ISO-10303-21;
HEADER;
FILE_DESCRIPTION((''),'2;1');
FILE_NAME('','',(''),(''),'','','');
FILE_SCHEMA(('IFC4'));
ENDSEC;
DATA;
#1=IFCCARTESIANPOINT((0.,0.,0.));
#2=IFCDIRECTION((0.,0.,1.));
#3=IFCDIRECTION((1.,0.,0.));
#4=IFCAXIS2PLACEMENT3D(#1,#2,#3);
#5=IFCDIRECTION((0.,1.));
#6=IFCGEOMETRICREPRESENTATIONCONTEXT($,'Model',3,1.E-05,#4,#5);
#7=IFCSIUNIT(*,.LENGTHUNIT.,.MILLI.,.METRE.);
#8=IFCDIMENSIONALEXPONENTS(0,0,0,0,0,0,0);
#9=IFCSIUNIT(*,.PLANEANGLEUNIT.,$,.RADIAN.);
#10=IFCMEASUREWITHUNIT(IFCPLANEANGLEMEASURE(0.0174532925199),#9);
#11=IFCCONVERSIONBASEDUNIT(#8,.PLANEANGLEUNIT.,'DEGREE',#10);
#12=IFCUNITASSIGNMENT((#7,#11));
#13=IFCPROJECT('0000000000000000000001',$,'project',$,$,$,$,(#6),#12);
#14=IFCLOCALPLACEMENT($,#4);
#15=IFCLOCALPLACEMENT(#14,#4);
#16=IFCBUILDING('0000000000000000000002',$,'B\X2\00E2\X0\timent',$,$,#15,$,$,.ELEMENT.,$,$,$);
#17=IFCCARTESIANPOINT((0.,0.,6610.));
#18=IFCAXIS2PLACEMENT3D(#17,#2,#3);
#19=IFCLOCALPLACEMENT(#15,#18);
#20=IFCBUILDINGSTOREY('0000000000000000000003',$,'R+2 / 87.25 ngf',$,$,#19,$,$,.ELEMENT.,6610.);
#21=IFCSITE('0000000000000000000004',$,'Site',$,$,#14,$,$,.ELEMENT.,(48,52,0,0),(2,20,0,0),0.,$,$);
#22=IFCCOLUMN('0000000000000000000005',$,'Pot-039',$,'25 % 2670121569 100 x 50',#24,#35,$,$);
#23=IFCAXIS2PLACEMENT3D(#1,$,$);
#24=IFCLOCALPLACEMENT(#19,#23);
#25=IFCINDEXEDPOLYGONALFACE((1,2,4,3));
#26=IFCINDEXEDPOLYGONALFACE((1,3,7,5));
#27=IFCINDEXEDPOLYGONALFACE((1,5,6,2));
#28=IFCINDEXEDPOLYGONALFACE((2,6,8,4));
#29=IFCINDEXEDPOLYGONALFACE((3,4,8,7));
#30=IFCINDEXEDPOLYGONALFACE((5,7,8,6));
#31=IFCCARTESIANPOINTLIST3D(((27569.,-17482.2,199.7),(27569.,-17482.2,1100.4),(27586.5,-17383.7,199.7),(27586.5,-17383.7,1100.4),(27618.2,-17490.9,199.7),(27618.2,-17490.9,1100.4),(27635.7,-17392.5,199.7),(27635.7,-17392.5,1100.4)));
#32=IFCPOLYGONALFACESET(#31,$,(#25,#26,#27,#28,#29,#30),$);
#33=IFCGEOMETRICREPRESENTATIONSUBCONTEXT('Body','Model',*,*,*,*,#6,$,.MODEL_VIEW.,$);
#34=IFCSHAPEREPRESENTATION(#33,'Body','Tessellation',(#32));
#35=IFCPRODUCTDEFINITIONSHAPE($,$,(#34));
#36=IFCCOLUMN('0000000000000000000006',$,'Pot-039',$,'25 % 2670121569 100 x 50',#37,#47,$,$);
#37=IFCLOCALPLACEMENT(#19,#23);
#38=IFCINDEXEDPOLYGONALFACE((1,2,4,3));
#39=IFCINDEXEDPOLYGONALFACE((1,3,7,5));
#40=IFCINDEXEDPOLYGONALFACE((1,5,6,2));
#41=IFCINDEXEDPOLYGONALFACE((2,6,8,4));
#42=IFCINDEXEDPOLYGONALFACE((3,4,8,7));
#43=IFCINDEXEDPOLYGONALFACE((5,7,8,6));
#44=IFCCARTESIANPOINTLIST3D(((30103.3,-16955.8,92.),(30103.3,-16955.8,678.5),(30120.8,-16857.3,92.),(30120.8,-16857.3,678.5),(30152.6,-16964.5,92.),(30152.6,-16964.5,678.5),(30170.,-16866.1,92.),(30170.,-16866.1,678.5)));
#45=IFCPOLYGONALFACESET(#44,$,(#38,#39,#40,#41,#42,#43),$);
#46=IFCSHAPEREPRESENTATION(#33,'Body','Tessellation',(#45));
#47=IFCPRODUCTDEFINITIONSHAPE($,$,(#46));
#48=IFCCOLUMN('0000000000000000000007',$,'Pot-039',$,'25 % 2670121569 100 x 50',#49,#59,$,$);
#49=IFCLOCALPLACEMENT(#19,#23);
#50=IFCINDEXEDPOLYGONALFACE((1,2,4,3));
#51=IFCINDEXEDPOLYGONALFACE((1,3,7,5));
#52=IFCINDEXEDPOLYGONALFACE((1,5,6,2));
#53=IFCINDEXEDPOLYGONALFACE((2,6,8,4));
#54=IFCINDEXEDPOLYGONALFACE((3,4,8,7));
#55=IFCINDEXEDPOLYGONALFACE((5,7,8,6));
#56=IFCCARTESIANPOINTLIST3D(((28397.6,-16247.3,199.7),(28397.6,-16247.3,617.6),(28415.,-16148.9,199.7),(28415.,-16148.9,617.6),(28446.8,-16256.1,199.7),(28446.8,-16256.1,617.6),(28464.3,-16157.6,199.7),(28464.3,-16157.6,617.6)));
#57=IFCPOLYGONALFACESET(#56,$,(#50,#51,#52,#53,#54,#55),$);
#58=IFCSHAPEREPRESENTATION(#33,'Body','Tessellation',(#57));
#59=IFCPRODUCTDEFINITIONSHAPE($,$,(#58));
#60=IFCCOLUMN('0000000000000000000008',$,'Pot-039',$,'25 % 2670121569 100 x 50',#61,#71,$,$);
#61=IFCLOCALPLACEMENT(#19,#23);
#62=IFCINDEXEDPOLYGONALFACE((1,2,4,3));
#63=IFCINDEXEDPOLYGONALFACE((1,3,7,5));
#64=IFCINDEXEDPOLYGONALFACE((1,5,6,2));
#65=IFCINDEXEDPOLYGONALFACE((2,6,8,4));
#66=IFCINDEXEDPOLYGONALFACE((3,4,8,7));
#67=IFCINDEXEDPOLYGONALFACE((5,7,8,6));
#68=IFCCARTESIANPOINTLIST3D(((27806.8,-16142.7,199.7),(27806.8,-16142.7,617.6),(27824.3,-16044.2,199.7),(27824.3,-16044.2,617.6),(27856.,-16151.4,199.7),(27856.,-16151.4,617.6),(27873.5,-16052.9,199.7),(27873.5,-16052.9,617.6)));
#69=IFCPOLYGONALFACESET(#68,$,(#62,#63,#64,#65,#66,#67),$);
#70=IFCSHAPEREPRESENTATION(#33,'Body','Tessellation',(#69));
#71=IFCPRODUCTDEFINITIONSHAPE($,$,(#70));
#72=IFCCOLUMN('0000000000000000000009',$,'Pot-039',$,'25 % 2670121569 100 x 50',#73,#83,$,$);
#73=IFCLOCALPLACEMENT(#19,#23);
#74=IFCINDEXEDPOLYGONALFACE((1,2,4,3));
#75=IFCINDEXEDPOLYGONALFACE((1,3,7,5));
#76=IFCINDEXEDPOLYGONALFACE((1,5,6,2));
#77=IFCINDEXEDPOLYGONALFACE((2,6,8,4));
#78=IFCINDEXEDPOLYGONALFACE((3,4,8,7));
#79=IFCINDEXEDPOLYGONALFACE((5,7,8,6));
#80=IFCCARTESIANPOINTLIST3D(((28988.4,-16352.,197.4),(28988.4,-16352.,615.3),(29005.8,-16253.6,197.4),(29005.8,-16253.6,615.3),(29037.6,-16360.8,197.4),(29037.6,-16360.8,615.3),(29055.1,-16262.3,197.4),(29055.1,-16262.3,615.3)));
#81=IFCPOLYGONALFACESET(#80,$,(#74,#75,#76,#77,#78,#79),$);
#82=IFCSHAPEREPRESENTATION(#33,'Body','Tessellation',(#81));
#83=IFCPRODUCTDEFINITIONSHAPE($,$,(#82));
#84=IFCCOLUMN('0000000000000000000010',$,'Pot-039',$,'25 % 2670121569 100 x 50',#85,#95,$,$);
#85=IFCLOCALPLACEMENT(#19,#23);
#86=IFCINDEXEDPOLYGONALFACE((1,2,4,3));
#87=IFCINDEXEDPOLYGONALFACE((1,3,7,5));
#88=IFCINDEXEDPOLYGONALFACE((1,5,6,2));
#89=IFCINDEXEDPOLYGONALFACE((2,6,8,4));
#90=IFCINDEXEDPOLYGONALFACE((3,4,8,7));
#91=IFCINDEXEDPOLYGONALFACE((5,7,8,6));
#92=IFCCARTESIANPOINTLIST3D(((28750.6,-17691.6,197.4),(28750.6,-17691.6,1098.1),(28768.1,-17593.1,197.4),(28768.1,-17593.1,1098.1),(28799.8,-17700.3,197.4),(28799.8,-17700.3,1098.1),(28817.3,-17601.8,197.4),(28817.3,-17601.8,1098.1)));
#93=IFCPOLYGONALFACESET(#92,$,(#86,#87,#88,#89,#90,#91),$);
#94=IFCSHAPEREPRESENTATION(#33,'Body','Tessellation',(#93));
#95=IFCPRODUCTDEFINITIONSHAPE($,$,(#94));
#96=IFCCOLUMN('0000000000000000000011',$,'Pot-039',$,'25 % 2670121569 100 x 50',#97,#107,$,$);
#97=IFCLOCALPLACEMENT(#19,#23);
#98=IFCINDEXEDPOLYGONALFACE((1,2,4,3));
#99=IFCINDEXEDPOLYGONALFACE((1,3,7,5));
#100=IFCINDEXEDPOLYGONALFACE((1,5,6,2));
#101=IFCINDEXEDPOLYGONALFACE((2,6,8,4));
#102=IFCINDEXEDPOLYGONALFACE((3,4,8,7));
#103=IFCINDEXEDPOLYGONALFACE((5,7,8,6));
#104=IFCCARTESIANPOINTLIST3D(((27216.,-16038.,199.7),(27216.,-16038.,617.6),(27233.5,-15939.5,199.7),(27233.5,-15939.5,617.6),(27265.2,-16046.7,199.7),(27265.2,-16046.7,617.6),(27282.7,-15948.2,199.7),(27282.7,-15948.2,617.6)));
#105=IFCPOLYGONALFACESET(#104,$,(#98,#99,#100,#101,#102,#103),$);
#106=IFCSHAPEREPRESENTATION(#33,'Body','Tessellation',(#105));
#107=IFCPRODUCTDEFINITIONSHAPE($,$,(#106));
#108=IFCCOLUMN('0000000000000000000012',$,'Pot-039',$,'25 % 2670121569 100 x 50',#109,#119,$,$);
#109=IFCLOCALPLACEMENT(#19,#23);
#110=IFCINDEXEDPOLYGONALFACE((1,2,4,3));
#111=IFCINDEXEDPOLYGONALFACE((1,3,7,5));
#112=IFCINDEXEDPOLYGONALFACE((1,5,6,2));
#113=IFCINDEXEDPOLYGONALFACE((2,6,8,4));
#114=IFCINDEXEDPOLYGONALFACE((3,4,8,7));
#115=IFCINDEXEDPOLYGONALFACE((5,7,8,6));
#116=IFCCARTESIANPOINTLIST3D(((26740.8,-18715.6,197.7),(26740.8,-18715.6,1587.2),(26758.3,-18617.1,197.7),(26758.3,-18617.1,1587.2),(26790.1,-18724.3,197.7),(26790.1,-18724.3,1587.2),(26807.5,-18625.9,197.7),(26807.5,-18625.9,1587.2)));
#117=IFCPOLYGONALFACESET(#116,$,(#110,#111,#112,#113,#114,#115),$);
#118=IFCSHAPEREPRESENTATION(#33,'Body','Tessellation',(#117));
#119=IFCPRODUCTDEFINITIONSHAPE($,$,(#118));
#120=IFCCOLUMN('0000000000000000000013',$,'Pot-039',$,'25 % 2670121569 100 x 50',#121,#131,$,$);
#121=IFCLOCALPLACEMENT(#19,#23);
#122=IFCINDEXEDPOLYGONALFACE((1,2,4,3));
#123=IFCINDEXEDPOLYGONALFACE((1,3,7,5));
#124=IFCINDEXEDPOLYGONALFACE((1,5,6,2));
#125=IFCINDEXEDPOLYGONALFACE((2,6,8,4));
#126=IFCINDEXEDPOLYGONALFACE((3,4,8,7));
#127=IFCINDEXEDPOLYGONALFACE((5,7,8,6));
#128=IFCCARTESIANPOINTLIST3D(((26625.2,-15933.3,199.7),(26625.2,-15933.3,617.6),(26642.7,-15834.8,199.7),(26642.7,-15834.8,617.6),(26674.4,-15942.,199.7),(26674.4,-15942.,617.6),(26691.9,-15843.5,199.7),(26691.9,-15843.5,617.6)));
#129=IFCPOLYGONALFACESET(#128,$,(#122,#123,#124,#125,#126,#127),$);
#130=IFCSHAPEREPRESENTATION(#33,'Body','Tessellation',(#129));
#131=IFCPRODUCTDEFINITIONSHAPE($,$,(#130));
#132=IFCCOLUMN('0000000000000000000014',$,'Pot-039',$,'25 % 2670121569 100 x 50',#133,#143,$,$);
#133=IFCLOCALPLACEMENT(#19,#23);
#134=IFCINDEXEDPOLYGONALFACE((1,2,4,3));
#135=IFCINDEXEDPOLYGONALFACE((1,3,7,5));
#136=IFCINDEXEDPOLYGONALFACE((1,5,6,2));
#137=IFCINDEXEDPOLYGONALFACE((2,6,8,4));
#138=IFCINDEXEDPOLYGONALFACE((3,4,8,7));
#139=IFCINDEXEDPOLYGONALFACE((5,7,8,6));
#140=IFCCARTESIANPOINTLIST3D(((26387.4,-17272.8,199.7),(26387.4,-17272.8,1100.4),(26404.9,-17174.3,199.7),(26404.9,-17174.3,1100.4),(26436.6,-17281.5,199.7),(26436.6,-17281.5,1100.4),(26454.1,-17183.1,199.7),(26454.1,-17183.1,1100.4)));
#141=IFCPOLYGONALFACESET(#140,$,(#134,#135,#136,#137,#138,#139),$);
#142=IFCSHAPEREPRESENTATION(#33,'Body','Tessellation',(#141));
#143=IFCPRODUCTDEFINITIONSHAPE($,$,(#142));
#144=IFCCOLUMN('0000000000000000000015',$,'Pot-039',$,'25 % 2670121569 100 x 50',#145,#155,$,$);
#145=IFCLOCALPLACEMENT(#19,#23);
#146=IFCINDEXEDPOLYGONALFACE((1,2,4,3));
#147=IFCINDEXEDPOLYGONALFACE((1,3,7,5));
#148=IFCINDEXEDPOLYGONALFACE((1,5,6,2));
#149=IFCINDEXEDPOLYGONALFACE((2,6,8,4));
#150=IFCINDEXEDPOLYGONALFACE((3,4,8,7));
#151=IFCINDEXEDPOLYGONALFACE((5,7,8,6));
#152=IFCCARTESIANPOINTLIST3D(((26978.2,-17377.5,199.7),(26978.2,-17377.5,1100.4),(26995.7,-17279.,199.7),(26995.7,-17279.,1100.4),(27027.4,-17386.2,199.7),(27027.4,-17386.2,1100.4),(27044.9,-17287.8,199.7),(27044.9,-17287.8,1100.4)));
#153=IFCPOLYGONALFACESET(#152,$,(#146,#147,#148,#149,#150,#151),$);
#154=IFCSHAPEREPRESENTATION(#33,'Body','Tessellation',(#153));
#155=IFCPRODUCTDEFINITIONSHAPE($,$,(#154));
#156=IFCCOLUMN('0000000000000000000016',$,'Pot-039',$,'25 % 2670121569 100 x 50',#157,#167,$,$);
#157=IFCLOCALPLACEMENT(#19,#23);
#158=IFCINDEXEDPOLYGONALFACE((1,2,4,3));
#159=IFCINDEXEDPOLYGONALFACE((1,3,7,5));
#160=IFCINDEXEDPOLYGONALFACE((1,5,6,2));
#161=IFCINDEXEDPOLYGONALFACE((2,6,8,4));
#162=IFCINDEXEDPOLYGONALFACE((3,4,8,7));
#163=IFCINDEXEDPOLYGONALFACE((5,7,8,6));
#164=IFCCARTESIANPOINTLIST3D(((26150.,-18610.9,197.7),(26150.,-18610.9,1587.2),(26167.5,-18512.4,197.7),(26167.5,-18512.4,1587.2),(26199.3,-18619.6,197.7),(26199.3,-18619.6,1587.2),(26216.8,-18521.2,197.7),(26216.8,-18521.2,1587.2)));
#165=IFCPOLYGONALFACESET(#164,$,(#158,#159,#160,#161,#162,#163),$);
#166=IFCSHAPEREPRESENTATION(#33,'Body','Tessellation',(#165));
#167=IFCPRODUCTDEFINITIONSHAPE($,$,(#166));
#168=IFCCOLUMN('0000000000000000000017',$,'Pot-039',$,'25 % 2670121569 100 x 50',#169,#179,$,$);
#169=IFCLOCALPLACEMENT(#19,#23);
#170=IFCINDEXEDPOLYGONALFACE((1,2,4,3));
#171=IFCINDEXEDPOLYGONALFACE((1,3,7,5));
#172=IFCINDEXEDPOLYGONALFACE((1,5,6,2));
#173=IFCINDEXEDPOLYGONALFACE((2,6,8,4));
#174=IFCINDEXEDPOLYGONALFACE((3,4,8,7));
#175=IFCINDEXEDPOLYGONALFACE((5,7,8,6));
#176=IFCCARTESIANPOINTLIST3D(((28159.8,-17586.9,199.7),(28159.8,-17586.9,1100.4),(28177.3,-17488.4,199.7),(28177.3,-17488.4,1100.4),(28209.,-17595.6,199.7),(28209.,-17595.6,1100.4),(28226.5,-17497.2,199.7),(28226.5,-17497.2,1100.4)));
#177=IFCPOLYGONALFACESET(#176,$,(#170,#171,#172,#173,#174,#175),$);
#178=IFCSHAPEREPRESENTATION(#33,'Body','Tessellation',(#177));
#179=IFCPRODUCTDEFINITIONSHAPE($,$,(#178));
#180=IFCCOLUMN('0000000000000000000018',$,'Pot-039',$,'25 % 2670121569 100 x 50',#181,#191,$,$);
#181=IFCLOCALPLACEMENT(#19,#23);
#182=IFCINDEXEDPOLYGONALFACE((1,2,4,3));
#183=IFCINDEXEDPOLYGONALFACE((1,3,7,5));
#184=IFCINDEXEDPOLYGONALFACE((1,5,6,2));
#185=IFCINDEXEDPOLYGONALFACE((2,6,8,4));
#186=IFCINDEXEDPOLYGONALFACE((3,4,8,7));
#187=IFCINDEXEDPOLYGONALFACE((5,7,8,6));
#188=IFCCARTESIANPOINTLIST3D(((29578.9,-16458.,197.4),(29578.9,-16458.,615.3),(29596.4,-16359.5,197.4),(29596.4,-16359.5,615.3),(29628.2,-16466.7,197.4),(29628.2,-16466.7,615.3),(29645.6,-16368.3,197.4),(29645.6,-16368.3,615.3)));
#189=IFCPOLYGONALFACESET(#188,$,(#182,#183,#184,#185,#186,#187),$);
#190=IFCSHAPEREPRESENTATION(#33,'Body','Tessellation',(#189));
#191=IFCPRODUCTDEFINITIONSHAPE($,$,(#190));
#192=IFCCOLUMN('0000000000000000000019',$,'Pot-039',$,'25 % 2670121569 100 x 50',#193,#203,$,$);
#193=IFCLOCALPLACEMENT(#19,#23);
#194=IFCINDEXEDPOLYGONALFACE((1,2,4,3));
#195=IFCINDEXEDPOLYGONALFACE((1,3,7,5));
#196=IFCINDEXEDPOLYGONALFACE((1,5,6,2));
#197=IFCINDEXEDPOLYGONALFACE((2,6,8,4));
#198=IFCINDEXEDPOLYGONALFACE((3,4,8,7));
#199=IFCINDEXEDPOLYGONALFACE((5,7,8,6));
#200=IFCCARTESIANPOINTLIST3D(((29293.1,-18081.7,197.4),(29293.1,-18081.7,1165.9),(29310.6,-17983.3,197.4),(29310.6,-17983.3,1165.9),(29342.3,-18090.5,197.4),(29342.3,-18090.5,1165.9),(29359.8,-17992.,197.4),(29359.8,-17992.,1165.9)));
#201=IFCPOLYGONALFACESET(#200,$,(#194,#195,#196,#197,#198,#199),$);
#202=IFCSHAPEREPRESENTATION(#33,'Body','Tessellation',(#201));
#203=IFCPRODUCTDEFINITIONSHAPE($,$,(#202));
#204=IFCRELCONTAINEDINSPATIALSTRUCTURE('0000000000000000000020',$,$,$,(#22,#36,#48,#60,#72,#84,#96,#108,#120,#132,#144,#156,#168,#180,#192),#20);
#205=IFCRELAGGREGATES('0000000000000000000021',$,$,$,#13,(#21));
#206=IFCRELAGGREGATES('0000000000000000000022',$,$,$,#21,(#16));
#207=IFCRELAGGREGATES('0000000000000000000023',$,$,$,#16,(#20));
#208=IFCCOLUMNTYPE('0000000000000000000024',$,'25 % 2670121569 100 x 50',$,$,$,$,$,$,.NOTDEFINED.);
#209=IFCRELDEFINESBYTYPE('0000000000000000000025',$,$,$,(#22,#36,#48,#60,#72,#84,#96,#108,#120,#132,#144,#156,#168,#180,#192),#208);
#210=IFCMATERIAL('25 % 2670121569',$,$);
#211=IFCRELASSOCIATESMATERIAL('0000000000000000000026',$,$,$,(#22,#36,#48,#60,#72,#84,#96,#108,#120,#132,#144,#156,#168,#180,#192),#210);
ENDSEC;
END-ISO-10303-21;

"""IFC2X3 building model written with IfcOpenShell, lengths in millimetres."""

from ifc_helpers import new_model, entity, si_unit, converted_unit, direction, frame, origin_with_axes, origin_2d_with_axis, place, context, subcontext, project, spatial, rectangle, extrude, material, type_object, element, save


model = new_model("IFC2X3")

# Units and contexts
model_context = context("Model", 3, precision=1e-05, world=origin_with_axes(), true_north=direction((0.0, 1.0)))
body_context = subcontext(model_context, "Body", "Model", "MODEL_VIEW")
ifc_project = project(units=[si_unit("LENGTHUNIT", "METRE", prefix="MILLI"), converted_unit("PLANEANGLEUNIT", "DEGREE", entity("IfcPlaneAngleMeasure", 0.0174532925199), si_unit("PLANEANGLEUNIT", "RADIAN"), dimensions=[0, 0, 0, 0, 0, 0, 0])], contexts=[model_context])

# Site, building, storey
site_placement = place(None, origin_with_axes())
site = spatial("IfcSite", under=ifc_project, at=site_placement, Name="Site", CompositionType="ELEMENT", RefLatitude=(48, 52, 0, 0), RefLongitude=(2, 20, 0, 0), RefElevation=0.0)
building_placement = place(site_placement, origin_with_axes())
building = spatial("IfcBuilding", under=site, at=building_placement, Name="Bâtiment", CompositionType="ELEMENT")
storey_placement = place(building_placement, frame((0.0, 0.0, 6610.0), z_axis=(0.0, 0.0, 1.0), x_axis=(1.0, 0.0, 0.0)))
storey = spatial("IfcBuildingStorey", under=building, at=storey_placement, Name="R+2 / 87.25 ngf", CompositionType="ELEMENT", Elevation=6610.0)

# Columns
ifc_material_1 = material(Name="25 % 2670121569")
column_type = type_object("IfcColumnType", Name="25 % 2670121569 100 x 50", PredefinedType="NOTDEFINED")
column_1_placement = place(storey_placement, frame((27602.4, -17437.3, 199.7), z_axis=(0.0, 0.0, 1.0), x_axis=(0.17478, 0.984607, 0.0)))
element("IfcColumn", 1, at=column_1_placement, inside=storey, type_object=column_type, material=ifc_material_1, Name="Pot-039", ObjectType="25 % 2670121569 100 x 50", context=body_context, shape_type="SweptSolid", body=[
    extrude(rectangle(XDim=100.0, YDim=50.0, at=origin_2d_with_axis()), origin_with_axes(), (0.0, 0.0, 1.0), 900.7),
])
column_2_placement = place(storey_placement, frame((30136.7, -16910.9, 92.0), z_axis=(0.0, 0.0, 1.0), x_axis=(0.17478, 0.984607, 0.0)))
element("IfcColumn", 2, at=column_2_placement, inside=storey, type_object=column_type, material=ifc_material_1, Name="Pot-039", ObjectType="25 % 2670121569 100 x 50", context=body_context, shape_type="SweptSolid", body=[
    extrude(rectangle(XDim=100.0, YDim=50.0, at=origin_2d_with_axis()), origin_with_axes(), (0.0, 0.0, 1.0), 586.5),
])
for number, where, z_axis, x_axis, name in (
    (3, (28430.9, -16202.5, 199.7), (0.0, 0.0, 1.0), (0.17478, 0.984607, 0.0), "Pot-039"),
    (4, (27840.1, -16097.8, 199.7), (0.0, 0.0, 1.0), (0.17478, 0.984607, 0.0), "Pot-039"),
    (5, (29021.7, -16307.2, 197.4), (0.0, 0.0, 1.0), (0.17478, 0.984607, 0.0), "Pot-039"),
):
    element("IfcColumn", number, at=place(storey_placement, frame(where, z_axis=z_axis, x_axis=x_axis)), inside=storey, type_object=column_type, material=ifc_material_1, Name=name, ObjectType="25 % 2670121569 100 x 50", context=body_context, shape_type="SweptSolid", body=[
        extrude(rectangle(XDim=100.0, YDim=50.0, at=origin_2d_with_axis()), origin_with_axes(), (0.0, 0.0, 1.0), 417.8),
    ])
column_3_placement = place(storey_placement, frame((28784.0, -17646.7, 197.4), z_axis=(0.0, 0.0, 1.0), x_axis=(0.17478, 0.984607, 0.0)))
element("IfcColumn", 6, at=column_3_placement, inside=storey, type_object=column_type, material=ifc_material_1, Name="Pot-039", ObjectType="25 % 2670121569 100 x 50", context=body_context, shape_type="SweptSolid", body=[
    extrude(rectangle(XDim=100.0, YDim=50.0, at=origin_2d_with_axis()), origin_with_axes(), (0.0, 0.0, 1.0), 900.7),
])
column_4_placement = place(storey_placement, frame((27249.3, -15993.1, 199.7), z_axis=(0.0, 0.0, 1.0), x_axis=(0.17478, 0.984607, 0.0)))
element("IfcColumn", 7, at=column_4_placement, inside=storey, type_object=column_type, material=ifc_material_1, Name="Pot-039", ObjectType="25 % 2670121569 100 x 50", context=body_context, shape_type="SweptSolid", body=[
    extrude(rectangle(XDim=100.0, YDim=50.0, at=origin_2d_with_axis()), origin_with_axes(), (0.0, 0.0, 1.0), 417.8),
])
column_5_placement = place(storey_placement, frame((26774.2, -18670.7, 197.7), z_axis=(0.0, 0.0, 1.0), x_axis=(0.17478, 0.984607, 0.0)))
element("IfcColumn", 8, at=column_5_placement, inside=storey, type_object=column_type, material=ifc_material_1, Name="Pot-039", ObjectType="25 % 2670121569 100 x 50", context=body_context, shape_type="SweptSolid", body=[
    extrude(rectangle(XDim=100.0, YDim=50.0, at=origin_2d_with_axis()), origin_with_axes(), (0.0, 0.0, 1.0), 1389.5),
])
column_6_placement = place(storey_placement, frame((26658.5, -15888.4, 199.7), z_axis=(0.0, 0.0, 1.0), x_axis=(0.17478, 0.984607, 0.0)))
element("IfcColumn", 9, at=column_6_placement, inside=storey, type_object=column_type, material=ifc_material_1, Name="Pot-039", ObjectType="25 % 2670121569 100 x 50", context=body_context, shape_type="SweptSolid", body=[
    extrude(rectangle(XDim=100.0, YDim=50.0, at=origin_2d_with_axis()), origin_with_axes(), (0.0, 0.0, 1.0), 417.8),
])
for number, where, z_axis, x_axis, name in (
    (10, (26420.8, -17227.9, 199.7), (0.0, 0.0, 1.0), (0.17478, 0.984607, 0.0), "Pot-039"),
    (11, (27011.6, -17332.6, 199.7), (0.0, 0.0, 1.0), (0.17478, 0.984607, 0.0), "Pot-039"),
):
    element("IfcColumn", number, at=place(storey_placement, frame(where, z_axis=z_axis, x_axis=x_axis)), inside=storey, type_object=column_type, material=ifc_material_1, Name=name, ObjectType="25 % 2670121569 100 x 50", context=body_context, shape_type="SweptSolid", body=[
        extrude(rectangle(XDim=100.0, YDim=50.0, at=origin_2d_with_axis()), origin_with_axes(), (0.0, 0.0, 1.0), 900.7),
    ])
column_7_placement = place(storey_placement, frame((26183.4, -18566.0, 197.7), z_axis=(0.0, 0.0, 1.0), x_axis=(0.17478, 0.984607, 0.0)))
element("IfcColumn", 12, at=column_7_placement, inside=storey, type_object=column_type, material=ifc_material_1, Name="Pot-039", ObjectType="25 % 2670121569 100 x 50", context=body_context, shape_type="SweptSolid", body=[
    extrude(rectangle(XDim=100.0, YDim=50.0, at=origin_2d_with_axis()), origin_with_axes(), (0.0, 0.0, 1.0), 1389.5),
])
column_8_placement = place(storey_placement, frame((28193.2, -17542.0, 199.7), z_axis=(0.0, 0.0, 1.0), x_axis=(0.17478, 0.984607, 0.0)))
element("IfcColumn", 13, at=column_8_placement, inside=storey, type_object=column_type, material=ifc_material_1, Name="Pot-039", ObjectType="25 % 2670121569 100 x 50", context=body_context, shape_type="SweptSolid", body=[
    extrude(rectangle(XDim=100.0, YDim=50.0, at=origin_2d_with_axis()), origin_with_axes(), (0.0, 0.0, 1.0), 900.7),
])
column_9_placement = place(storey_placement, frame((29612.3, -16413.1, 197.4), z_axis=(0.0, 0.0, 1.0), x_axis=(0.17478, 0.984607, 0.0)))
element("IfcColumn", 14, at=column_9_placement, inside=storey, type_object=column_type, material=ifc_material_1, Name="Pot-039", ObjectType="25 % 2670121569 100 x 50", context=body_context, shape_type="SweptSolid", body=[
    extrude(rectangle(XDim=100.0, YDim=50.0, at=origin_2d_with_axis()), origin_with_axes(), (0.0, 0.0, 1.0), 417.8),
])
column_10_placement = place(storey_placement, frame((29326.5, -18036.9, 197.4), z_axis=(0.0, 0.0, 1.0), x_axis=(0.17478, 0.984607, 0.0)))
element("IfcColumn", 15, at=column_10_placement, inside=storey, type_object=column_type, material=ifc_material_1, Name="Pot-039", ObjectType="25 % 2670121569 100 x 50", context=body_context, shape_type="SweptSolid", body=[
    extrude(rectangle(XDim=100.0, YDim=50.0, at=origin_2d_with_axis()), origin_with_axes(), (0.0, 0.0, 1.0), 968.5),
])

save(model, "model.ifc")
